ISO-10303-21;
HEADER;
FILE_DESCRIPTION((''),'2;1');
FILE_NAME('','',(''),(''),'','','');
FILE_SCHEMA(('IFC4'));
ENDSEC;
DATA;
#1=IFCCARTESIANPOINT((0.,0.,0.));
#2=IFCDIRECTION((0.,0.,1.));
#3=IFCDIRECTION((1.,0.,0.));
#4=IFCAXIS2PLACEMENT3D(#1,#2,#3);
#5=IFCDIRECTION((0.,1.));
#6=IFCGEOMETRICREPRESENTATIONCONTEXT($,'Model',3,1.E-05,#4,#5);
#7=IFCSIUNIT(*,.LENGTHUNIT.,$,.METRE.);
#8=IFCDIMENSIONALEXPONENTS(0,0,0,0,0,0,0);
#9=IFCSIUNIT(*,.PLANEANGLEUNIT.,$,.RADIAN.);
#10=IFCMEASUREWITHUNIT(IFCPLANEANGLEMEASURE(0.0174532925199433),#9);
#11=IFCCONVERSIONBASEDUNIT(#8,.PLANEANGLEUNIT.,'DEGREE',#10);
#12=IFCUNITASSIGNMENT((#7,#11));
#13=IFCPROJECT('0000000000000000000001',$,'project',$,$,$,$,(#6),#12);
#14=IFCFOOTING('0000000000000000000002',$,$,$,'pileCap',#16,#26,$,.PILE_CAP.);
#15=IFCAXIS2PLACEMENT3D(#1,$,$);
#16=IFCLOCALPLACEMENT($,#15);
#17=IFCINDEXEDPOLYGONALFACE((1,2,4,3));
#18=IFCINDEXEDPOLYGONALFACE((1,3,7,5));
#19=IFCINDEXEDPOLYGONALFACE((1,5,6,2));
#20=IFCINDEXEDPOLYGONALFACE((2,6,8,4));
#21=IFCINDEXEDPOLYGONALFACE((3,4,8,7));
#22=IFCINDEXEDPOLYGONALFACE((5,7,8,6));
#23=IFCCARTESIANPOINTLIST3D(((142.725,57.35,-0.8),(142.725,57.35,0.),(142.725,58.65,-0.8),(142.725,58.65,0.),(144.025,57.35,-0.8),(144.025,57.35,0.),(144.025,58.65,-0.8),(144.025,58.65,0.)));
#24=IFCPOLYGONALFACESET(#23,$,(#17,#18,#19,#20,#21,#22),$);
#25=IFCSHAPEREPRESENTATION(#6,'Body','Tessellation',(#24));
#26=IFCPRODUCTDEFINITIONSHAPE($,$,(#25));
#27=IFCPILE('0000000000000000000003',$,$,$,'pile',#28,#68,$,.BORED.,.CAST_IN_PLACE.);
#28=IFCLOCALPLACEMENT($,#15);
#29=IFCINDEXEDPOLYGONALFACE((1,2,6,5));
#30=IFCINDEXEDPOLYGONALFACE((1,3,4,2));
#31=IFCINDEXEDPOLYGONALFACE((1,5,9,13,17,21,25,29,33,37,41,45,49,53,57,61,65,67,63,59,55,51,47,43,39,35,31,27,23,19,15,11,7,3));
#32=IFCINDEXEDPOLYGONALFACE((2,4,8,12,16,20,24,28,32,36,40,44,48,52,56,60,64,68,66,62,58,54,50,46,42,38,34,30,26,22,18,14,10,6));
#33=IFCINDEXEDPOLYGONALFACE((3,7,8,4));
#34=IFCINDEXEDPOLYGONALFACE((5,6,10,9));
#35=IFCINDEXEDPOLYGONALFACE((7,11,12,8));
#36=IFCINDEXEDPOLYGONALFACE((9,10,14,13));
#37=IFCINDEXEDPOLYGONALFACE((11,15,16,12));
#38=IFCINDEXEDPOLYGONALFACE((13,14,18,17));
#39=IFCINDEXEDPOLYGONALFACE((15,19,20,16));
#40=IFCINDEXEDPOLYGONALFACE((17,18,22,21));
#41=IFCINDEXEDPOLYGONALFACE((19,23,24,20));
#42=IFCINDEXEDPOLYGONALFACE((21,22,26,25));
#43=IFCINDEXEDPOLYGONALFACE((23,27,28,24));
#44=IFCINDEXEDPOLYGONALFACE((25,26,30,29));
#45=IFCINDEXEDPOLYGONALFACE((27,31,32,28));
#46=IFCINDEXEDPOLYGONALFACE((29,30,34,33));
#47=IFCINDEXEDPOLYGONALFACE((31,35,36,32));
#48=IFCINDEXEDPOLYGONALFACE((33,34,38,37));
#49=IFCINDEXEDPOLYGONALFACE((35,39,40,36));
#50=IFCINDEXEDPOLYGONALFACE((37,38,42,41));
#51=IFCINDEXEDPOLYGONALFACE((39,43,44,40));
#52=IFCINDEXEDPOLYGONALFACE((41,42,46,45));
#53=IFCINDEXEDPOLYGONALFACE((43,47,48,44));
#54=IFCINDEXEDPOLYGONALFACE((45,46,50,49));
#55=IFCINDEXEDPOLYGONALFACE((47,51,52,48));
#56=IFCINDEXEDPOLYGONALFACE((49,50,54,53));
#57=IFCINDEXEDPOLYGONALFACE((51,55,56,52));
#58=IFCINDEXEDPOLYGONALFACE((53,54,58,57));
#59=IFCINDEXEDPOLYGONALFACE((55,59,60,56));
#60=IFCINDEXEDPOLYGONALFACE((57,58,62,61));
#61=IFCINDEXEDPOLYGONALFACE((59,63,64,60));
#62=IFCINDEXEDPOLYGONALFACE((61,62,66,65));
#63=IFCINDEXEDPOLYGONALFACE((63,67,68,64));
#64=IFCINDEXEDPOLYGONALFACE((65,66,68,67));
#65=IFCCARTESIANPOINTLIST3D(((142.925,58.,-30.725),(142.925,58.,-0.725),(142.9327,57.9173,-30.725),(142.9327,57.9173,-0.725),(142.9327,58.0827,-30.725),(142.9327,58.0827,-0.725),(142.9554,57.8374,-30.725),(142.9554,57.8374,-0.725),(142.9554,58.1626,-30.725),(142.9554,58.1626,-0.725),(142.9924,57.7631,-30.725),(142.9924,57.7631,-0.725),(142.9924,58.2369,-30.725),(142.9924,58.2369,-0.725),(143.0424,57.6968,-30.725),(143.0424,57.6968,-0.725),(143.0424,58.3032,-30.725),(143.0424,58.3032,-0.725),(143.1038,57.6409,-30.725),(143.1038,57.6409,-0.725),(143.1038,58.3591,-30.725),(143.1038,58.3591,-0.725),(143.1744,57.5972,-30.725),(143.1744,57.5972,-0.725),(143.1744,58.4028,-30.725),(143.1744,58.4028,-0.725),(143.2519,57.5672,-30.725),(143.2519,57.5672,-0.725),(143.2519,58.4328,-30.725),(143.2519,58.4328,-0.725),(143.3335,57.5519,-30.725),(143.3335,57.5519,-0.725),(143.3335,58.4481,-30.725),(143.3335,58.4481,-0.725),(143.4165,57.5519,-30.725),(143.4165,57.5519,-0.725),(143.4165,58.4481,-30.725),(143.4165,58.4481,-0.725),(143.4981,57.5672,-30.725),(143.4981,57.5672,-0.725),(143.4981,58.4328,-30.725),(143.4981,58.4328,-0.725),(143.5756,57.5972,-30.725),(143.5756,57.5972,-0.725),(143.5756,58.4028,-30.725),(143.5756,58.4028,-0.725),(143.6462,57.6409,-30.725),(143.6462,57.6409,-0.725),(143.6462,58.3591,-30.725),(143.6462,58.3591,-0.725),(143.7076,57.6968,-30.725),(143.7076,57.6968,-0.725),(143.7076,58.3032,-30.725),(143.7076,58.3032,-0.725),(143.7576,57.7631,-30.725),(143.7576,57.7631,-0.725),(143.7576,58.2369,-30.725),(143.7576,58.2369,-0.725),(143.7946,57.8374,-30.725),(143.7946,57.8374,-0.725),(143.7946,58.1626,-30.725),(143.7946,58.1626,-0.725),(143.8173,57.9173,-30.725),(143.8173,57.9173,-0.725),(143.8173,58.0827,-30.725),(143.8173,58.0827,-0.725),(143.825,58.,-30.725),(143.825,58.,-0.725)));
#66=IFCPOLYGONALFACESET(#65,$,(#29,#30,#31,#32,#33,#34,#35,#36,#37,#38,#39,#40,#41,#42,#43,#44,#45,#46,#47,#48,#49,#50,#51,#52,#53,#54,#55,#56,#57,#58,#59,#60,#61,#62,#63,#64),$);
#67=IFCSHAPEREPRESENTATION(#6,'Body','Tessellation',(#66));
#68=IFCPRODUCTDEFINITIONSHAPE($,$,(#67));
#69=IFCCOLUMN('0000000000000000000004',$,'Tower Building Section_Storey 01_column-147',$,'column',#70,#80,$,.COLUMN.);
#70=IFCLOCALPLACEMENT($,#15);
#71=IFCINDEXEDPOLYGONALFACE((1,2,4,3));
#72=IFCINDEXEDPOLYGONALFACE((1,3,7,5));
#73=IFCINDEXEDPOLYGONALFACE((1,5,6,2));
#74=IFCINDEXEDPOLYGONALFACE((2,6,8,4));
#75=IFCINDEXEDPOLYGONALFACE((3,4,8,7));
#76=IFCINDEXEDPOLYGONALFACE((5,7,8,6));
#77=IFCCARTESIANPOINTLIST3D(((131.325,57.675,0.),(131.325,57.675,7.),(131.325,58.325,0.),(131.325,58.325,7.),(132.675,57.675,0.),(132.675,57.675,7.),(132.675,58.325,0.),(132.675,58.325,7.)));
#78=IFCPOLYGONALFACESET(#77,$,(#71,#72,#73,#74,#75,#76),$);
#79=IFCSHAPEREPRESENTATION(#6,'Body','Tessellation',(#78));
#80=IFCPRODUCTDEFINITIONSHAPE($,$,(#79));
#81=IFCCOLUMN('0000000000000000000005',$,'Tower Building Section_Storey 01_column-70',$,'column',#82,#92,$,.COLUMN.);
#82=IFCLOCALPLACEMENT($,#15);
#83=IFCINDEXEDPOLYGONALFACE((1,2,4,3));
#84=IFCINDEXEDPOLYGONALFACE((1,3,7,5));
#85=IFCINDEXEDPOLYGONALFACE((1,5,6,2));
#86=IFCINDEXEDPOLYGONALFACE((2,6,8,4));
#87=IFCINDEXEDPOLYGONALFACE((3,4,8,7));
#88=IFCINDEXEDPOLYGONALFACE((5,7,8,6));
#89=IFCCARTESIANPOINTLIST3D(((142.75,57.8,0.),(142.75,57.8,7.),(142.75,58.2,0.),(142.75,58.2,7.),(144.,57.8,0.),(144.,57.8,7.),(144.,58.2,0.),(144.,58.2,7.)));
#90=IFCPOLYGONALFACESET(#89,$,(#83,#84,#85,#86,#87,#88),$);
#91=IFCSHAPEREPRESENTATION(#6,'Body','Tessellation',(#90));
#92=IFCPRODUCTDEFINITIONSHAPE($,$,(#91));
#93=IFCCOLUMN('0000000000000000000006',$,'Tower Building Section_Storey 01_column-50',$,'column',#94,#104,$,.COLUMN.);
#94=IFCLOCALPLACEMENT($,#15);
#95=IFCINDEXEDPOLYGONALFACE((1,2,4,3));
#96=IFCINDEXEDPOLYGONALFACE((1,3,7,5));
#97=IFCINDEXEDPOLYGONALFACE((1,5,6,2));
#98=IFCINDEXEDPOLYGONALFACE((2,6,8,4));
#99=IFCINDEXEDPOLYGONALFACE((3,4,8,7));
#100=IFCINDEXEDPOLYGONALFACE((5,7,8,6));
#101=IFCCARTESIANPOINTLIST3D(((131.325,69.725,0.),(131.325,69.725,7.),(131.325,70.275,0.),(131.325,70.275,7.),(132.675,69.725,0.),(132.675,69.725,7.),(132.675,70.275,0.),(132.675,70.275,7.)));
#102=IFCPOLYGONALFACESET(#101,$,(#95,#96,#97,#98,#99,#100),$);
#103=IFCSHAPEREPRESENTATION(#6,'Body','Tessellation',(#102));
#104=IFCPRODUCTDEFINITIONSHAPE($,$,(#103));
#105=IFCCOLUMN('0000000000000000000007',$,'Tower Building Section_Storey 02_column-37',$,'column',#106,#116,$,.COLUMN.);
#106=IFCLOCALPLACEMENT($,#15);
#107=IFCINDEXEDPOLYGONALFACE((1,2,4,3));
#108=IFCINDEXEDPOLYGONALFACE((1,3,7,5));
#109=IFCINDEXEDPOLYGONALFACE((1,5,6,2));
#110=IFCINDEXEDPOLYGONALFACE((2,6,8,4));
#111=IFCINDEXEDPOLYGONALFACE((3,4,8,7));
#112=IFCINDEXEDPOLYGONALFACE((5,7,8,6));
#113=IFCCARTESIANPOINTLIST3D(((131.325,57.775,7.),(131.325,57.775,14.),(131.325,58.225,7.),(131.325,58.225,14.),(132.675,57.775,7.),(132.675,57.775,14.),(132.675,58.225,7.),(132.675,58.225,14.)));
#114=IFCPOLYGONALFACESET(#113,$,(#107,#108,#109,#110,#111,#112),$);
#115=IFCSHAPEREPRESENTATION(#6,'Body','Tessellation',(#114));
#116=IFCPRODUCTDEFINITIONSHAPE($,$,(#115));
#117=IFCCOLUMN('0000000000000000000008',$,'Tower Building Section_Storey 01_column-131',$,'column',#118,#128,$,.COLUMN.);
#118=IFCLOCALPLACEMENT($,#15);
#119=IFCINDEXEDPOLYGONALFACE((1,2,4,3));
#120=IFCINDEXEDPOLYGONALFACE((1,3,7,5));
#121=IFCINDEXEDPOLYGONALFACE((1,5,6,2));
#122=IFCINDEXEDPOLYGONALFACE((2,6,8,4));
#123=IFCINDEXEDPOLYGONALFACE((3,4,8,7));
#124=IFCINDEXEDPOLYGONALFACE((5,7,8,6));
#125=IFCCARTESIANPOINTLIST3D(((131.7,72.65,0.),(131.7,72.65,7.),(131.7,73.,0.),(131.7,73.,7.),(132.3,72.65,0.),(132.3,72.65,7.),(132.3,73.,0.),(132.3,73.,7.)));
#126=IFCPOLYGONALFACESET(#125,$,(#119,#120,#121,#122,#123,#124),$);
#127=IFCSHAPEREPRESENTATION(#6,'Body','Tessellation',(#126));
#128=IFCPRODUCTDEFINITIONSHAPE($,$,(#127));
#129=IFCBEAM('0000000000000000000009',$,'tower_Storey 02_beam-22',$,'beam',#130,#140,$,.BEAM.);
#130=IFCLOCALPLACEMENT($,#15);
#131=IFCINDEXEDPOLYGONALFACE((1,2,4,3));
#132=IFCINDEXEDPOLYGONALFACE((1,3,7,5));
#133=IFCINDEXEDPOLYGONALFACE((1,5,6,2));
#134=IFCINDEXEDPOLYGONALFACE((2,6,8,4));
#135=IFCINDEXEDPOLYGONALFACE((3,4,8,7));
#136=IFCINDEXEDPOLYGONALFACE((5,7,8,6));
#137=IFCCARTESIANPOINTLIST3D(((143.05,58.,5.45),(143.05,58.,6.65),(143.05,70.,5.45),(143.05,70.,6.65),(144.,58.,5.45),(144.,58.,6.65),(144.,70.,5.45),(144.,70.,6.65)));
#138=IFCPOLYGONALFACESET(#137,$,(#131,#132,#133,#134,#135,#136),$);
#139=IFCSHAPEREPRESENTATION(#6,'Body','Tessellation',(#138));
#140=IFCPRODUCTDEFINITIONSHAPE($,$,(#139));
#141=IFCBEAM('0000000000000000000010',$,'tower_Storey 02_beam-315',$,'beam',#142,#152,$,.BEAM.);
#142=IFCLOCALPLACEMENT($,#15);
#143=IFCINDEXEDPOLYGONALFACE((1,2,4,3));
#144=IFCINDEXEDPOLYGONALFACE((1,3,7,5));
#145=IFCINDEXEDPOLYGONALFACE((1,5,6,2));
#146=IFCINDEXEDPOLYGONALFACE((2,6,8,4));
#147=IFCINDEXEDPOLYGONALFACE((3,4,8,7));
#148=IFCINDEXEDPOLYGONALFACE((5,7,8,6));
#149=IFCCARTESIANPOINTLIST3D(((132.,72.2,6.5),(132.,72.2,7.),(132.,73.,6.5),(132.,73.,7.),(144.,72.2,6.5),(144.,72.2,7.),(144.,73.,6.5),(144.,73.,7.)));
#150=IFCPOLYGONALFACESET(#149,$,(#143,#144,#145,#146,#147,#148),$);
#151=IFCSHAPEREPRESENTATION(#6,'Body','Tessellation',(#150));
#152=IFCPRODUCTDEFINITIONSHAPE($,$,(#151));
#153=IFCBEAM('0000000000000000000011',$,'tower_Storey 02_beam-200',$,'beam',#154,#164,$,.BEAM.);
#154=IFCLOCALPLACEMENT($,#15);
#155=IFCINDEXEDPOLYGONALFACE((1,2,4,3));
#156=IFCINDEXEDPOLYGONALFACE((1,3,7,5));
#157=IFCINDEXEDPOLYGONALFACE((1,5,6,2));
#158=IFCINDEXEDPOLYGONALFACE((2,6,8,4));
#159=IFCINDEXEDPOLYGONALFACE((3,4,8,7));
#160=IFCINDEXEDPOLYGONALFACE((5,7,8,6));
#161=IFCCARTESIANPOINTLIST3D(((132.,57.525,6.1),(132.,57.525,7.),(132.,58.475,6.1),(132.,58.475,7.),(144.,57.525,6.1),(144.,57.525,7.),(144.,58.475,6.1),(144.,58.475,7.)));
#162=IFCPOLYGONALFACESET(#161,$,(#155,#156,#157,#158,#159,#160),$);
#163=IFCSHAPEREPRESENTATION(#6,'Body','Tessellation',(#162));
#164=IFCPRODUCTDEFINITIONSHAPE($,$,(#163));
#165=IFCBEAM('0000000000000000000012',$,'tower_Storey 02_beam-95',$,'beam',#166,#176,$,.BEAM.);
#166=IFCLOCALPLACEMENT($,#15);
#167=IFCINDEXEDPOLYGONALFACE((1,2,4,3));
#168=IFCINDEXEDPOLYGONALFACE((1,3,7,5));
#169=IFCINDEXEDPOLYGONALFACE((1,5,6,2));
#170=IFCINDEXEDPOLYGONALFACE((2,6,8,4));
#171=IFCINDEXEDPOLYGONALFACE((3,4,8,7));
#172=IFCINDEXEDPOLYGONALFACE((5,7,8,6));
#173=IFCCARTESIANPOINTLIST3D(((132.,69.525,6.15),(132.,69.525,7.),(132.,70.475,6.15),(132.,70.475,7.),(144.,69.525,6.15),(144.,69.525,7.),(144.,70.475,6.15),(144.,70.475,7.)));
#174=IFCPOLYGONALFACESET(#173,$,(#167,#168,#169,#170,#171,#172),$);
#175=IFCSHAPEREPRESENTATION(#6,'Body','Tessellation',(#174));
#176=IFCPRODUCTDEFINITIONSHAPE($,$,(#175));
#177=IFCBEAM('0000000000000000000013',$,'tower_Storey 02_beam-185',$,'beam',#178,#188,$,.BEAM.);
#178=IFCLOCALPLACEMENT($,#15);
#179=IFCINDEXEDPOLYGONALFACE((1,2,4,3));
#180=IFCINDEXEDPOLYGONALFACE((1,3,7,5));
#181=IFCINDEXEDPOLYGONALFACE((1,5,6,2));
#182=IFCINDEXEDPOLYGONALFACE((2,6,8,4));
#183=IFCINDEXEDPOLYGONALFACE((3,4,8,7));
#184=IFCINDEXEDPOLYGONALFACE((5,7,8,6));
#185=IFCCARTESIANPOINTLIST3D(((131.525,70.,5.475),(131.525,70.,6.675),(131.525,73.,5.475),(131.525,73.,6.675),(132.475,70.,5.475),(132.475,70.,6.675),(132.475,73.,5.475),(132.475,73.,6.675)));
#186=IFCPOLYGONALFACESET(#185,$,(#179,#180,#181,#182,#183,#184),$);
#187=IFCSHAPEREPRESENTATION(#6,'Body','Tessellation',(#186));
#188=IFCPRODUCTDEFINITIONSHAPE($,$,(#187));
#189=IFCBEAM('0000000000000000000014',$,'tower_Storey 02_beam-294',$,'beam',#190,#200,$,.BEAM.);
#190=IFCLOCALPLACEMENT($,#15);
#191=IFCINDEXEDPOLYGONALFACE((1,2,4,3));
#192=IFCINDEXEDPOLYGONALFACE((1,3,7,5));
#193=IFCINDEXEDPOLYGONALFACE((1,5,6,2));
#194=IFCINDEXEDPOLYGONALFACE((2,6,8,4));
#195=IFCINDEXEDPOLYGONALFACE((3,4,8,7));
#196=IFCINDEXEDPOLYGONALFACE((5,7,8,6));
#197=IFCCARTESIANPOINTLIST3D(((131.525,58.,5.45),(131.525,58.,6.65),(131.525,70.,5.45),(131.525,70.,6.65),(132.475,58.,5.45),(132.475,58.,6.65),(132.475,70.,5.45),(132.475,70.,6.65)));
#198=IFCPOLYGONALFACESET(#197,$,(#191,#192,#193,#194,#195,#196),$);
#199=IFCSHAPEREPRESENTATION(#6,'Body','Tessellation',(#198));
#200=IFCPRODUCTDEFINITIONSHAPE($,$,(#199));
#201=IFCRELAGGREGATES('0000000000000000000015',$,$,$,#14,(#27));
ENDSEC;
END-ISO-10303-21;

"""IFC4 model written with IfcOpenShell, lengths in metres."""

from ifc_helpers import new_model, entity, si_unit, converted_unit, direction, frame, origin_with_axes, place, context, project, polyline, circle_curve, parameter, trimmed, segment, composite_curve, outline, extrude, element, aggregate, save


model = new_model("IFC4")

# Units and contexts
model_context = context("Model", 3, precision=1e-05, world=origin_with_axes(), true_north=direction((0.0, 1.0)))
ifc_project = project(units=[si_unit("LENGTHUNIT", "METRE"), converted_unit("PLANEANGLEUNIT", "DEGREE", entity("IfcPlaneAngleMeasure", 0.0174532925199433), si_unit("PLANEANGLEUNIT", "RADIAN"), dimensions=[0, 0, 0, 0, 0, 0, 0])], contexts=[model_context])

# Footing
placement_1 = place(None, origin_with_axes())
placement_2 = place(placement_1, origin_with_axes())
footing_1_placement = place(placement_2, frame((143.375, 58.0, -0.8), z_axis=(0.0, 0.0, 1.0), x_axis=(1.0, 0.0, 0.0)))
footing_1 = element("IfcFooting", 1, at=footing_1_placement, ObjectType="pileCap", PredefinedType="PILE_CAP", context=model_context, body=[
    extrude(outline(polyline([(0.65, -0.65, 0.0), (0.65, 0.65, 0.0), (-0.65, 0.65, 0.0), (-0.65, -0.65, 0.0), (0.65, -0.65, 0.0)])), origin_with_axes(), (0.0, 0.0, 1.0), 0.8),
])

# Pile
pile_1_placement = place(footing_1_placement, frame((0.0, 0.0, -29.925), z_axis=(0.0, 0.0, 1.0), x_axis=(1.0, 0.0, 0.0)))
pile_1 = element("IfcPile", 2, at=pile_1_placement, ObjectType="pile", ConstructionType="CAST_IN_PLACE", PredefinedType="BORED", context=model_context, body=[
    extrude(outline(composite_curve([segment(trimmed(circle_curve(origin_with_axes(), 0.45), [parameter(0.0)], [parameter(360.0)], True, "PARAMETER"), True, "CONTINUOUS")], self_intersect=False)), origin_with_axes(), (0.0, 0.0, 1.0), 30.0),
])
aggregate(footing_1, [pile_1])

# Columns
column_1_placement = place(placement_2, frame((132.0, 58.0, 0.0), z_axis=(0.0, 0.0, 1.0), x_axis=(1.0, 0.0, 0.0)))
element("IfcColumn", 3, at=column_1_placement, Name="Tower Building Section_Storey 01_column-147", ObjectType="column", PredefinedType="COLUMN", context=model_context, body=[
    extrude(outline(polyline([(-0.675, -0.325, 0.0), (0.675, -0.325, 0.0), (0.675, 0.325, 0.0), (-0.675, 0.325, 0.0), (-0.675, -0.325, 0.0)])), origin_with_axes(), (0.0, 0.0, 1.0), 7.0),
])
column_2_placement = place(placement_2, frame((143.375, 58.0, 0.0), z_axis=(0.0, 0.0, 1.0), x_axis=(1.0, 0.0, 0.0)))
element("IfcColumn", 4, at=column_2_placement, Name="Tower Building Section_Storey 01_column-70", ObjectType="column", PredefinedType="COLUMN", context=model_context, body=[
    extrude(outline(polyline([(-0.625, -0.2, 0.0), (0.625, -0.2, 0.0), (0.625, 0.2, 0.0), (-0.625, 0.2, 0.0), (-0.625, -0.2, 0.0)])), origin_with_axes(), (0.0, 0.0, 1.0), 7.0),
])
column_3_placement = place(placement_2, frame((132.0, 70.0, 0.0), z_axis=(0.0, 0.0, 1.0), x_axis=(1.0, 0.0, 0.0)))
element("IfcColumn", 5, at=column_3_placement, Name="Tower Building Section_Storey 01_column-50", ObjectType="column", PredefinedType="COLUMN", context=model_context, body=[
    extrude(outline(polyline([(-0.675, -0.275, 0.0), (0.675, -0.275, 0.0), (0.675, 0.275, 0.0), (-0.675, 0.275, 0.0), (-0.675, -0.275, 0.0)])), origin_with_axes(), (0.0, 0.0, 1.0), 7.0),
])
placement_3 = place(placement_1, frame((0.0, 0.0, 7.0), z_axis=(0.0, 0.0, 1.0), x_axis=(1.0, 0.0, 0.0)))
column_4_placement = place(placement_3, frame((132.0, 58.0, 0.0), z_axis=(0.0, 0.0, 1.0), x_axis=(1.0, 0.0, 0.0)))
element("IfcColumn", 6, at=column_4_placement, Name="Tower Building Section_Storey 02_column-37", ObjectType="column", PredefinedType="COLUMN", context=model_context, body=[
    extrude(outline(polyline([(-0.675, -0.225, 0.0), (0.675, -0.225, 0.0), (0.675, 0.225, 0.0), (-0.675, 0.225, 0.0), (-0.675, -0.225, 0.0)])), origin_with_axes(), (0.0, 0.0, 1.0), 7.0),
])
column_5_placement = place(placement_2, frame((132.0, 72.825, 0.0), z_axis=(0.0, 0.0, 1.0), x_axis=(1.0, 0.0, 0.0)))
element("IfcColumn", 7, at=column_5_placement, Name="Tower Building Section_Storey 01_column-131", ObjectType="column", PredefinedType="COLUMN", context=model_context, body=[
    extrude(outline(polyline([(-0.3, -0.175, 0.0), (0.3, -0.175, 0.0), (0.3, 0.175, 0.0), (-0.3, 0.175, 0.0), (-0.3, -0.175, 0.0)])), origin_with_axes(), (0.0, 0.0, 1.0), 7.0),
])

# Beams
beam_1_placement = place(placement_3, frame((143.525, 58.0, -0.95), z_axis=(0.0, 1.0, 0.0), x_axis=(-1.0, 0.0, 0.0)))
element("IfcBeam", 8, at=beam_1_placement, Name="tower_Storey 02_beam-22", ObjectType="beam", PredefinedType="BEAM", context=model_context, body=[
    extrude(outline(polyline([(0.475, 0.6, 0.0), (-0.475, 0.6, 0.0), (-0.475, -0.6, 0.0), (0.475, -0.6, 0.0), (0.475, 0.6, 0.0)])), origin_with_axes(), (0.0, 0.0, 1.0), 12.0),
])
beam_2_placement = place(placement_3, frame((132.0, 72.6, -0.25), z_axis=(1.0, 0.0, 0.0), x_axis=(0.0, 1.0, 0.0)))
element("IfcBeam", 9, at=beam_2_placement, Name="tower_Storey 02_beam-315", ObjectType="beam", PredefinedType="BEAM", context=model_context, body=[
    extrude(outline(polyline([(0.4, 0.25, 0.0), (-0.4, 0.25, 0.0), (-0.4, -0.25, 0.0), (0.4, -0.25, 0.0), (0.4, 0.25, 0.0)])), origin_with_axes(), (0.0, 0.0, 1.0), 12.0),
])
beam_3_placement = place(placement_3, frame((132.0, 58.0, -0.45), z_axis=(1.0, 0.0, 0.0), x_axis=(0.0, 1.0, 0.0)))
element("IfcBeam", 10, at=beam_3_placement, Name="tower_Storey 02_beam-200", ObjectType="beam", PredefinedType="BEAM", context=model_context, body=[
    extrude(outline(polyline([(0.475, 0.45, 0.0), (-0.475, 0.45, 0.0), (-0.475, -0.45, 0.0), (0.475, -0.45, 0.0), (0.475, 0.45, 0.0)])), origin_with_axes(), (0.0, 0.0, 1.0), 12.0),
])
beam_4_placement = place(placement_3, frame((132.0, 70.0, -0.425), z_axis=(1.0, 0.0, 0.0), x_axis=(0.0, 1.0, 0.0)))
element("IfcBeam", 11, at=beam_4_placement, Name="tower_Storey 02_beam-95", ObjectType="beam", PredefinedType="BEAM", context=model_context, body=[
    extrude(outline(polyline([(0.475, 0.425, 0.0), (-0.475, 0.425, 0.0), (-0.475, -0.425, 0.0), (0.475, -0.425, 0.0), (0.475, 0.425, 0.0)])), origin_with_axes(), (0.0, 0.0, 1.0), 12.0),
])
beam_5_placement = place(placement_3, frame((132.0, 70.0, -0.925), z_axis=(0.0, 1.0, 0.0), x_axis=(-1.0, 0.0, 0.0)))
element("IfcBeam", 12, at=beam_5_placement, Name="tower_Storey 02_beam-185", ObjectType="beam", PredefinedType="BEAM", context=model_context, body=[
    extrude(outline(polyline([(0.475, 0.6, 0.0), (-0.475, 0.6, 0.0), (-0.475, -0.6, 0.0), (0.475, -0.6, 0.0), (0.475, 0.6, 0.0)])), origin_with_axes(), (0.0, 0.0, 1.0), 3.0),
])
beam_6_placement = place(placement_3, frame((132.0, 58.0, -0.95), z_axis=(0.0, 1.0, 0.0), x_axis=(-1.0, 0.0, 0.0)))
element("IfcBeam", 13, at=beam_6_placement, Name="tower_Storey 02_beam-294", ObjectType="beam", PredefinedType="BEAM", context=model_context, body=[
    extrude(outline(polyline([(0.475, 0.6, 0.0), (-0.475, 0.6, 0.0), (-0.475, -0.6, 0.0), (0.475, -0.6, 0.0), (0.475, 0.6, 0.0)])), origin_with_axes(), (0.0, 0.0, 1.0), 12.0),
])

save(model, "model.ifc")
